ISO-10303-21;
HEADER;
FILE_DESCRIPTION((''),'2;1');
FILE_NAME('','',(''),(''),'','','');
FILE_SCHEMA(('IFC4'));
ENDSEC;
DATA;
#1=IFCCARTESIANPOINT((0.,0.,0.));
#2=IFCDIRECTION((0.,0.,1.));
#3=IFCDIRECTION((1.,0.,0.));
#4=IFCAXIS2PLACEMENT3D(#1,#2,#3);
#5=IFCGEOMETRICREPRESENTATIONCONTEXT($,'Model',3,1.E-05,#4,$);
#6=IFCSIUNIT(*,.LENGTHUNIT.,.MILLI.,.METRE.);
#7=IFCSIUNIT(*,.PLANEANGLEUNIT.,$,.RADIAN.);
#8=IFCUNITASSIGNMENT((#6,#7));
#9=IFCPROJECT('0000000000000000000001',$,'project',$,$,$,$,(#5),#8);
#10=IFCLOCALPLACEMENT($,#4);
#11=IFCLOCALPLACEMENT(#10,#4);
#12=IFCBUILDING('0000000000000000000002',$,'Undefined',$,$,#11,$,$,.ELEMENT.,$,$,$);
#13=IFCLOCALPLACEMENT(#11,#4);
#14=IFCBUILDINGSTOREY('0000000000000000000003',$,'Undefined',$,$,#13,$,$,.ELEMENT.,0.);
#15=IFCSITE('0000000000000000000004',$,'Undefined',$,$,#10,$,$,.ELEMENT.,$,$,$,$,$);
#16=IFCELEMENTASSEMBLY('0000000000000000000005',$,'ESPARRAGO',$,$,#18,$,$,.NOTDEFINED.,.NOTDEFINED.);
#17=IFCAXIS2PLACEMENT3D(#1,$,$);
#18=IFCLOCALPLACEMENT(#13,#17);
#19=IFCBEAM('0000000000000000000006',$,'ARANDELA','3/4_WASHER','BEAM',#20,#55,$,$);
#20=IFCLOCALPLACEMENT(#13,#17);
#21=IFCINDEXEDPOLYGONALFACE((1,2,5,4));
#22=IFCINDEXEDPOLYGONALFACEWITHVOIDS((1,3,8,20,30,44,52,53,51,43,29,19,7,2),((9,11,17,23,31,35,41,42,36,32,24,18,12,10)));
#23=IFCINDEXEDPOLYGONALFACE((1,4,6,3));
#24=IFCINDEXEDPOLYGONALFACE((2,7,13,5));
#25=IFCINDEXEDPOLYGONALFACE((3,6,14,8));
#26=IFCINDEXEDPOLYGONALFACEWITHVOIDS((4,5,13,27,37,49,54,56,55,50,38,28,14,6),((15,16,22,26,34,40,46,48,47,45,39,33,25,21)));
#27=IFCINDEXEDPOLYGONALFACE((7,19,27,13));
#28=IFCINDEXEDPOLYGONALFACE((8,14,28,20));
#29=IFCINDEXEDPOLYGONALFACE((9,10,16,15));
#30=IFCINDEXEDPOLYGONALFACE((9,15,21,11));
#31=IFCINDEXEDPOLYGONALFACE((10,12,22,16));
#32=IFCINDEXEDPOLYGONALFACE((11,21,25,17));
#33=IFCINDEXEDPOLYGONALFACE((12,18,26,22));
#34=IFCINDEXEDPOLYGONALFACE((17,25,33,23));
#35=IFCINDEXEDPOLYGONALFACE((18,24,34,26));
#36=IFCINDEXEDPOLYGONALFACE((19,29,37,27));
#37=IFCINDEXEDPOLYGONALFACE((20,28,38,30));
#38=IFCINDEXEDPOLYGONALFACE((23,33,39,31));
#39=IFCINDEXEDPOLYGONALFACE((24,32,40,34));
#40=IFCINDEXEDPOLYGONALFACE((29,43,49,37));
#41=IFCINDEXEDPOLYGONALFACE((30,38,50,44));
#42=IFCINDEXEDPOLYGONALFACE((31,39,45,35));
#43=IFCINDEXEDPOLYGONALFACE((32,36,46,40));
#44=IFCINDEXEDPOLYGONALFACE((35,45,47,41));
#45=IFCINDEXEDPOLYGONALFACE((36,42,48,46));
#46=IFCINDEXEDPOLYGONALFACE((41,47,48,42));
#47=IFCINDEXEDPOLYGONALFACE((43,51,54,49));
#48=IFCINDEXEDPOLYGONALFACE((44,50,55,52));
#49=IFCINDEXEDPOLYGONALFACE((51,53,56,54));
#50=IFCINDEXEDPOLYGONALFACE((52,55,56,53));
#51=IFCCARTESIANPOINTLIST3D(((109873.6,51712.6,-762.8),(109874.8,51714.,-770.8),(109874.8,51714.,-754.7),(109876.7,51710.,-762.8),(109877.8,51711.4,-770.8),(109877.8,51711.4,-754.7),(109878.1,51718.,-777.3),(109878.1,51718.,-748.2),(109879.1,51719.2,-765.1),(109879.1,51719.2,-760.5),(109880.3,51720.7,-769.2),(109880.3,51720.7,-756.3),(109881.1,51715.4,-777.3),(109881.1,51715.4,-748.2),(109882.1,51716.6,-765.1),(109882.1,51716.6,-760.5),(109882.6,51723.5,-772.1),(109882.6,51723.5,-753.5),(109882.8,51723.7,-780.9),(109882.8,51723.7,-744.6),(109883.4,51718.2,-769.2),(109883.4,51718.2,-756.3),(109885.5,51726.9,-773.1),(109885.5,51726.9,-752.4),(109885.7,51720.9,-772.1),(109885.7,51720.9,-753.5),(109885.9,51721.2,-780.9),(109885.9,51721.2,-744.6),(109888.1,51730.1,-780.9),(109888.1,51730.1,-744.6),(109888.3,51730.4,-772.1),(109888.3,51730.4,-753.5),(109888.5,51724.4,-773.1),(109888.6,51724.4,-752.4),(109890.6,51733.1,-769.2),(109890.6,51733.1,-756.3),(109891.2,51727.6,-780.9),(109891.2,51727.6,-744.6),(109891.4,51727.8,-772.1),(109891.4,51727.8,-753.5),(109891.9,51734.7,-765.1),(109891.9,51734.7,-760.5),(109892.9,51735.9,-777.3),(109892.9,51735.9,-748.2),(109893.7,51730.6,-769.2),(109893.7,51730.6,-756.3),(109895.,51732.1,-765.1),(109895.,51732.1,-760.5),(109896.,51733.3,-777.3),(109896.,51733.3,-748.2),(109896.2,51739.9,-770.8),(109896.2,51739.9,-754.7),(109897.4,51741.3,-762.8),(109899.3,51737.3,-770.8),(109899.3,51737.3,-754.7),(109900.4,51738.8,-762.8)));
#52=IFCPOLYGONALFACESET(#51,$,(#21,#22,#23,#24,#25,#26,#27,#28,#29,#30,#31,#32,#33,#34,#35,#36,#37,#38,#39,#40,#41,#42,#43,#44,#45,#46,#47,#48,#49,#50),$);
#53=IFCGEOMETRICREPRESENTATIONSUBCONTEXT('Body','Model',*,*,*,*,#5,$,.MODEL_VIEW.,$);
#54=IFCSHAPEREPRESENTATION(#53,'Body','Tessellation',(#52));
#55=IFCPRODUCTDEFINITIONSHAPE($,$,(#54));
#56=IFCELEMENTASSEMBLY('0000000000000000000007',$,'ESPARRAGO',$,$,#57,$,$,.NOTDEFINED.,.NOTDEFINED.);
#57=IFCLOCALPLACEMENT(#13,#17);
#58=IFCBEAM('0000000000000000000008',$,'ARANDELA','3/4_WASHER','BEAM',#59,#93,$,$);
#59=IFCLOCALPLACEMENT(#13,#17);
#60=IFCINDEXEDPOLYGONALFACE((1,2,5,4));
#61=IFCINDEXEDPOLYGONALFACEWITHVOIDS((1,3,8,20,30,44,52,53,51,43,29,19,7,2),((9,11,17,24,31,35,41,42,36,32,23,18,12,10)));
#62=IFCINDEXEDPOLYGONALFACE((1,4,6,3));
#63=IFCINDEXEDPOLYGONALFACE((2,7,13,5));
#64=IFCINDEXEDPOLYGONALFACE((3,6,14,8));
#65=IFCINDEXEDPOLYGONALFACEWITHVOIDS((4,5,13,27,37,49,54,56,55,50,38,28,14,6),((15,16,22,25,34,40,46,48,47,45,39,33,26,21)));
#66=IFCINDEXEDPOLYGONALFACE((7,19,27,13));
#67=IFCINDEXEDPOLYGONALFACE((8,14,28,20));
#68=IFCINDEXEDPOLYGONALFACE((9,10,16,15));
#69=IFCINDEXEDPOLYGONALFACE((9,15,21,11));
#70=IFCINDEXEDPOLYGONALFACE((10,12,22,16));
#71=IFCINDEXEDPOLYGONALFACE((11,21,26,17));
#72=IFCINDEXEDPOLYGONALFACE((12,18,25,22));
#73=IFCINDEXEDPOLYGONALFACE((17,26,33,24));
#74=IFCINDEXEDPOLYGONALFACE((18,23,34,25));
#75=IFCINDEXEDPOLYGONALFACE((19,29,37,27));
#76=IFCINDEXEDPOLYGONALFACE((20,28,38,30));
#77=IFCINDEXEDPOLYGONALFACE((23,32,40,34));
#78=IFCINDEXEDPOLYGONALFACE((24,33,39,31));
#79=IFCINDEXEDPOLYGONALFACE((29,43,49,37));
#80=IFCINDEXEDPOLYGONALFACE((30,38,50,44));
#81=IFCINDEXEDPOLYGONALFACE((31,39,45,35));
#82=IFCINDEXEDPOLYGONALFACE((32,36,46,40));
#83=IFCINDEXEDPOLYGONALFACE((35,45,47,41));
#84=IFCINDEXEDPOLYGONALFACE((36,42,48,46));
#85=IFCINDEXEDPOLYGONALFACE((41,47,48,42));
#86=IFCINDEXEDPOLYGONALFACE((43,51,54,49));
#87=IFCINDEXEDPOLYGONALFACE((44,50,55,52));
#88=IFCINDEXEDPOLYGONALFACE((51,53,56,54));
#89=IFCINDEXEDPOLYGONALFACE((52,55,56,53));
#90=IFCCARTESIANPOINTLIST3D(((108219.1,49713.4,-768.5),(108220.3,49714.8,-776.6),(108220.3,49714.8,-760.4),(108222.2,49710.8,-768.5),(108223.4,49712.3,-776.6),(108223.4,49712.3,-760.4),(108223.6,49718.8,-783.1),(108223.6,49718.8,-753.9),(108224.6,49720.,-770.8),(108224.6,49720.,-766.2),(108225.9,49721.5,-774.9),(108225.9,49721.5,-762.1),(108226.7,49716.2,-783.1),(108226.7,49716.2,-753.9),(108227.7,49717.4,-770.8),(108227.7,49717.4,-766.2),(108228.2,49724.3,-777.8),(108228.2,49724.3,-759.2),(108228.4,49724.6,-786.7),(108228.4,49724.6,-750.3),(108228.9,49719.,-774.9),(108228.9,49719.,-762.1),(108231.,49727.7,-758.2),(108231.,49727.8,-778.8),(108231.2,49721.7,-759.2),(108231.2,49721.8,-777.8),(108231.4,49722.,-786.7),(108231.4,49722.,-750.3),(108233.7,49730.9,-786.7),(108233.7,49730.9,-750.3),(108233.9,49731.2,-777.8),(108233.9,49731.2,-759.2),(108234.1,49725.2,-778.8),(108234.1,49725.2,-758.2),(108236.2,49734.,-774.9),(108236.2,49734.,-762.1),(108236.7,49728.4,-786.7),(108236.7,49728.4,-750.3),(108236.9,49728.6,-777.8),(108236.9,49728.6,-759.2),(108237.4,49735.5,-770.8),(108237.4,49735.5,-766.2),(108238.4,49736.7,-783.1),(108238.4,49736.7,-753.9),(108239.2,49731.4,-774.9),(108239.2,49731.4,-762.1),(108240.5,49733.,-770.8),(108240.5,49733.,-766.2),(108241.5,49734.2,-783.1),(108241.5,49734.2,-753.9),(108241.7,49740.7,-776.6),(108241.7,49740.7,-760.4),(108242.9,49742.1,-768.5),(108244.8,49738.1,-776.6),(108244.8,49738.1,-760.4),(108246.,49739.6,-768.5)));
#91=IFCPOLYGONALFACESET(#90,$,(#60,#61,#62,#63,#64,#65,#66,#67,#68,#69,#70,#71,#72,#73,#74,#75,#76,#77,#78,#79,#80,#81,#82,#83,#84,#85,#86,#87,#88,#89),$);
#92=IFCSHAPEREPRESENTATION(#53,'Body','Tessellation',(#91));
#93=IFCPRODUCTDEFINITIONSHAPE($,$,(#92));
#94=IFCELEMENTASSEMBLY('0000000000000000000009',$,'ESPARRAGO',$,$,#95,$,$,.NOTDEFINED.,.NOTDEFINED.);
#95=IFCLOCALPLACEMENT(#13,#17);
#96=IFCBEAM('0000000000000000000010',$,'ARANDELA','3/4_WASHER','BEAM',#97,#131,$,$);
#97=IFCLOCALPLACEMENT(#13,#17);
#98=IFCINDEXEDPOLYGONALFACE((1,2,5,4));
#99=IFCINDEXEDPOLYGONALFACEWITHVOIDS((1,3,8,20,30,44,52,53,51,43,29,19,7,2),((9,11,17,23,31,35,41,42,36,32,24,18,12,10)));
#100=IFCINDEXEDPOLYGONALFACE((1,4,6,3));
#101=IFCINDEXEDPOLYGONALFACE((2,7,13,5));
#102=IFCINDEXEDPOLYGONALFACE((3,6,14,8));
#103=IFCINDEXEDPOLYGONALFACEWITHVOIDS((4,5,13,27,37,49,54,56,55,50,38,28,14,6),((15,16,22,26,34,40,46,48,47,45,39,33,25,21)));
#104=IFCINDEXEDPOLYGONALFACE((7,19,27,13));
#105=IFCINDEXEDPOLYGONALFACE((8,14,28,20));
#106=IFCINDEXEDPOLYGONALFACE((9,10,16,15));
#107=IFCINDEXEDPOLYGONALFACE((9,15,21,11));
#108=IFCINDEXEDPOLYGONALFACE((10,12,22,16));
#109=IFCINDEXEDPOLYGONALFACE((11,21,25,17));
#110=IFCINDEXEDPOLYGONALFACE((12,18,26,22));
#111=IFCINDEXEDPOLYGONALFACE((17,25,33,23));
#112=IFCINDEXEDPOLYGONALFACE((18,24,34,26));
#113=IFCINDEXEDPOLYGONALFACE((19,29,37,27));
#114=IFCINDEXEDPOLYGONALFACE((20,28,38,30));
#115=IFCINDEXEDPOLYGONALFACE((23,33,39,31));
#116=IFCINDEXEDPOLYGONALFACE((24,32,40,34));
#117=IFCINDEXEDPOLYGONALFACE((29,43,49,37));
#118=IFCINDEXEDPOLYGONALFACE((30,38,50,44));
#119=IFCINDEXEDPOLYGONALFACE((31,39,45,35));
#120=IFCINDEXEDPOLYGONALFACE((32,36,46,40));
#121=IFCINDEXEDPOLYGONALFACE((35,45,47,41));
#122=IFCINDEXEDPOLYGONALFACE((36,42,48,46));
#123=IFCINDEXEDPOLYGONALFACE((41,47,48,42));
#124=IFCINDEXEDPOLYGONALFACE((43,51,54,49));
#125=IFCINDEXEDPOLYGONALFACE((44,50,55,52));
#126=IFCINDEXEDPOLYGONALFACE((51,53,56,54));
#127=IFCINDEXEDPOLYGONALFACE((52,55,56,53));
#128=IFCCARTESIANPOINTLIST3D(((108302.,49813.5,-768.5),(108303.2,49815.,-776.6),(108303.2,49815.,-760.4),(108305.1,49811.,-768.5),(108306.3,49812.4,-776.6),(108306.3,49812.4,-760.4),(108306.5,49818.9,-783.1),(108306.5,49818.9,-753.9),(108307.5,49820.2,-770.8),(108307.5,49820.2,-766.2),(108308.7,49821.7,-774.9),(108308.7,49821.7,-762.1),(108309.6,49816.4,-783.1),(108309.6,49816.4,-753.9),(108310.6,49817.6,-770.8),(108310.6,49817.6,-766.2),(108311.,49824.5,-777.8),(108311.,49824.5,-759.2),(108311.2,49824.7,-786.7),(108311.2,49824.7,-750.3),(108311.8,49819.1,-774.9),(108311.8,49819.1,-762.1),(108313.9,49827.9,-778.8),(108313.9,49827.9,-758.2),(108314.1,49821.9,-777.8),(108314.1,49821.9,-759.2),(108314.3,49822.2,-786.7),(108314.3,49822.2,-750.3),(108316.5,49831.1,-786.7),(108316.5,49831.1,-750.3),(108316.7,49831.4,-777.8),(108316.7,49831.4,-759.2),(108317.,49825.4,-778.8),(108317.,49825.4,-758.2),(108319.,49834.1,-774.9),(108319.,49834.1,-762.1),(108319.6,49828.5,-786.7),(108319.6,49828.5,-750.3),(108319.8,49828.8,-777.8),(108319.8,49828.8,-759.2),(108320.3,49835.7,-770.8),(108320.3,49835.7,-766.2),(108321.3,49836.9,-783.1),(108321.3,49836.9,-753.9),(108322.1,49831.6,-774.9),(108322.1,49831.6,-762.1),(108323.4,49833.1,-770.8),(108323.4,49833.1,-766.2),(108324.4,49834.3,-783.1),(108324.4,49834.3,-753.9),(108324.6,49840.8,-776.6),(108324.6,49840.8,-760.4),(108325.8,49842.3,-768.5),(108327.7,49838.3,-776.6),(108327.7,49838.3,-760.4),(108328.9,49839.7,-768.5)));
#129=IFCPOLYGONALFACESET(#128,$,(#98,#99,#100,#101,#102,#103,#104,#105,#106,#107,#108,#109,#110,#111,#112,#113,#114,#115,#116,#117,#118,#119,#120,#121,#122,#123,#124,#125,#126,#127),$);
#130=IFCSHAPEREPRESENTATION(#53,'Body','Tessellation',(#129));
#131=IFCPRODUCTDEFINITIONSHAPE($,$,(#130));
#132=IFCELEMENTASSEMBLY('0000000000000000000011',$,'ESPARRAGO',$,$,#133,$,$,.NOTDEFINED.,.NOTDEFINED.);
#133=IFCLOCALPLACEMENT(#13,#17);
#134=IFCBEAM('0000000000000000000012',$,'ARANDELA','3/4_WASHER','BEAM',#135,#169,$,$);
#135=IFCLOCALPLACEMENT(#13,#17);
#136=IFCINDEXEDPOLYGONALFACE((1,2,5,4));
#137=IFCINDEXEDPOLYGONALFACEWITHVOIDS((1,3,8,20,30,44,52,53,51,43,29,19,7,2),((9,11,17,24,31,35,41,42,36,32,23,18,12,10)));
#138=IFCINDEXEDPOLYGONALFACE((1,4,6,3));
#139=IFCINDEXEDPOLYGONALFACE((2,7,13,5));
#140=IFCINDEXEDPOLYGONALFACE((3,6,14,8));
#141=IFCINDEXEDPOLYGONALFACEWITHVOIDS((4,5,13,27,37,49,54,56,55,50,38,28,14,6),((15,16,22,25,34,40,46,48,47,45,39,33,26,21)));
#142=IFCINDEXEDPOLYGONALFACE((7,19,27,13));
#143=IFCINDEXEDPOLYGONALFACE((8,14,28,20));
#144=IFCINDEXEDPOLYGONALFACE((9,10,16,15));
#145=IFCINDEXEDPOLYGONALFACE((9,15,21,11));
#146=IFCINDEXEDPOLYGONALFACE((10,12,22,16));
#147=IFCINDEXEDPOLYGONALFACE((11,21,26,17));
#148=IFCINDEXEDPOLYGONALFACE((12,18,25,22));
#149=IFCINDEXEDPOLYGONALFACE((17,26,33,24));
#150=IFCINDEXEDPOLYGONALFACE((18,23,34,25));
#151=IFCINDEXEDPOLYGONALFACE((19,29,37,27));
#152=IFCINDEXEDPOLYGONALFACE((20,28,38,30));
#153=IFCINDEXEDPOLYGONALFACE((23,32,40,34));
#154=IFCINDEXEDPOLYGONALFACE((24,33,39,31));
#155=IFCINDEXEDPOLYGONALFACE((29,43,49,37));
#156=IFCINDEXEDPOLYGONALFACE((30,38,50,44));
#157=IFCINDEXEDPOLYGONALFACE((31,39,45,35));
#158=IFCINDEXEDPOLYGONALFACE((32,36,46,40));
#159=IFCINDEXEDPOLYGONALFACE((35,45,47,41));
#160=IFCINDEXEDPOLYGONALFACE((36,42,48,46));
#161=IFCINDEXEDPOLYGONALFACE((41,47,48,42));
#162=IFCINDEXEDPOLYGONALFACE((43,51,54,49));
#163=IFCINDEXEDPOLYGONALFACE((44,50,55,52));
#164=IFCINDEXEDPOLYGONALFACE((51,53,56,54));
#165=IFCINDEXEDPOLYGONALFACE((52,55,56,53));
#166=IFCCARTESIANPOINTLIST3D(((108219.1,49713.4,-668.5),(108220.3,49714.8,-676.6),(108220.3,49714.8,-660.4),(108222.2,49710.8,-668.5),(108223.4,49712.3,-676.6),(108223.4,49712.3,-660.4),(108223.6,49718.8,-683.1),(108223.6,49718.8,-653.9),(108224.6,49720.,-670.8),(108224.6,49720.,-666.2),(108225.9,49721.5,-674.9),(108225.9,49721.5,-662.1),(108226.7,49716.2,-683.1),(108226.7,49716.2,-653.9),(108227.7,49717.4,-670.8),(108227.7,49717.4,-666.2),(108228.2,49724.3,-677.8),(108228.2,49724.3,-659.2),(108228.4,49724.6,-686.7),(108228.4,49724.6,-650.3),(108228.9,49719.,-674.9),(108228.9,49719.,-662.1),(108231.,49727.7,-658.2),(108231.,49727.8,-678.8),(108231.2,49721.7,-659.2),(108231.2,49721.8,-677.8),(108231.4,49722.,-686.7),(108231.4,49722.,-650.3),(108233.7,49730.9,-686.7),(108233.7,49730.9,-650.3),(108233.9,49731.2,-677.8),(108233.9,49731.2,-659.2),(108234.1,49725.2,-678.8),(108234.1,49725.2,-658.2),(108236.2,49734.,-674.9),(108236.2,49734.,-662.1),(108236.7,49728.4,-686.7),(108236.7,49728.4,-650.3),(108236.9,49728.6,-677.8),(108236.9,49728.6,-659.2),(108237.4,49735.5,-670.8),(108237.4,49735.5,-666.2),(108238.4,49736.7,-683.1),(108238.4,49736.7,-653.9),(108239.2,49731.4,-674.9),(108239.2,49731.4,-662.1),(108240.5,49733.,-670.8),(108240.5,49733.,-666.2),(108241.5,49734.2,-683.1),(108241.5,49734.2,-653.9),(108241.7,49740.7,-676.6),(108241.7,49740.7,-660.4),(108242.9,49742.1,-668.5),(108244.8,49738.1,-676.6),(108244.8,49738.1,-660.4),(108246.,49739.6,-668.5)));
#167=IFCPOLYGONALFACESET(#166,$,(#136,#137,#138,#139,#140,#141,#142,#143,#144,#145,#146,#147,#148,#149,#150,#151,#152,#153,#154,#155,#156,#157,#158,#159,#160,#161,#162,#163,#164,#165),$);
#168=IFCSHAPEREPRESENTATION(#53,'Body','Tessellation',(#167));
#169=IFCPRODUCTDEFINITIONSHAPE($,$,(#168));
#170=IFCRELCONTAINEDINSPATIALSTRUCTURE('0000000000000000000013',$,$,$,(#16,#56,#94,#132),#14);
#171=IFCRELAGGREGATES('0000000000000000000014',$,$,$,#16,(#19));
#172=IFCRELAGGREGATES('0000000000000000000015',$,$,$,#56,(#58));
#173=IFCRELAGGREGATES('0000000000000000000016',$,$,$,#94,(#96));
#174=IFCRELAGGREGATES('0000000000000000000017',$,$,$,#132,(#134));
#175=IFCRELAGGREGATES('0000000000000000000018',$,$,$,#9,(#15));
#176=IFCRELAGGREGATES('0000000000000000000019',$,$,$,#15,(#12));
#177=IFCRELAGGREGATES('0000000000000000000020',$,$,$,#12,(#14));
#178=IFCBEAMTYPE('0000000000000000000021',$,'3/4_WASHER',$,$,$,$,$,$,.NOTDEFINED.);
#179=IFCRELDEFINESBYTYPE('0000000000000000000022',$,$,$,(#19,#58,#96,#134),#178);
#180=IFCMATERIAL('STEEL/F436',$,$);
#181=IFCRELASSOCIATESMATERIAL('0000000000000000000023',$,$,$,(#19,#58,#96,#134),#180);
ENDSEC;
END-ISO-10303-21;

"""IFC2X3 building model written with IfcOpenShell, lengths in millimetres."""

from ifc_helpers import new_model, si_unit, frame, origin_with_axes, place, context, subcontext, project, spatial, polyline, outline, extrude, material, type_object, element, aggregate, save


model = new_model("IFC2X3")

# Units and contexts
model_context = context("Model", 3, precision=1e-05, world=origin_with_axes())
body_context = subcontext(model_context, "Body", "Model", "MODEL_VIEW")
ifc_project = project(units=[si_unit("LENGTHUNIT", "METRE", prefix="MILLI"), si_unit("PLANEANGLEUNIT", "RADIAN")], contexts=[model_context])

# Site, building, storey
site_placement = place(None, origin_with_axes())
site = spatial("IfcSite", under=ifc_project, at=site_placement, Name="Undefined", CompositionType="ELEMENT")
building_placement = place(site_placement, origin_with_axes())
building = spatial("IfcBuilding", under=site, at=building_placement, Name="Undefined", CompositionType="ELEMENT")
storey_placement = place(building_placement, origin_with_axes())
storey = spatial("IfcBuildingStorey", under=building, at=storey_placement, Name="Undefined", CompositionType="ELEMENT", Elevation=0.0)

# Element assemblies, beams
assembly_1_placement = place(storey_placement, origin_with_axes())
assembly_1 = element("IfcElementAssembly", 1, at=assembly_1_placement, inside=storey, Name="ESPARRAGO", AssemblyPlace="NOTDEFINED", PredefinedType="NOTDEFINED")
ifc_material_1 = material(Name="STEEL/F436")
beam_type_1 = type_object("IfcBeamType", Name="3/4_WASHER", PredefinedType="NOTDEFINED")
beam_1_placement = place(assembly_1_placement, frame((109885.5, 51726.9, -762.8), z_axis=(0.000066, -0.000055, 1.0), x_axis=(0.7704, -0.637561, -0.000086)))
beam_1 = element("IfcBeam", 2, at=beam_1_placement, type_object=beam_type_1, material=ifc_material_1, Name="ARANDELA", Description="3/4_WASHER", ObjectType="BEAM", context=body_context, shape_type="SweptSolid", body=[
    extrude(outline(polyline([(-11.6, -14.6), (-16.8, -8.1), (-18.6, 0.0), (-16.8, 8.1), (-11.6, 14.6), (-4.2, 18.2), (4.2, 18.2), (11.6, 14.6), (16.8, 8.1), (18.6, 0.0), (16.8, -8.1), (11.6, -14.6), (4.2, -18.2), (-4.2, -18.2), (-11.6, -14.6)]), holes=[polyline([(-4.5, 9.3), (-8.1, 6.4), (-10.1, 2.3), (-10.1, -2.3), (-8.1, -6.4), (-4.5, -9.3), (0.0, -10.3), (4.5, -9.3), (8.1, -6.4), (10.1, -2.3), (10.1, 2.3), (8.1, 6.4), (4.5, 9.3), (0.0, 10.3), (-4.5, 9.3)])]), frame((4.0, 0.0, 0.0), z_axis=(-1.0, 0.0, 0.0), x_axis=(0.0, -1.0, 0.0)), (0.0, 0.0, 1.0), 4.0),
])
aggregate(assembly_1, [beam_1])
assembly_2_placement = place(storey_placement, origin_with_axes())
assembly_2 = element("IfcElementAssembly", 3, at=assembly_2_placement, inside=storey, Name="ESPARRAGO", AssemblyPlace="NOTDEFINED", PredefinedType="NOTDEFINED")
beam_2_placement = place(assembly_2_placement, frame((108231.0, 49727.7, -768.5), z_axis=(0.000066, -0.000055, 1.0), x_axis=(0.7704, -0.637561, -0.000086)))
beam_2 = element("IfcBeam", 4, at=beam_2_placement, type_object=beam_type_1, material=ifc_material_1, Name="ARANDELA", Description="3/4_WASHER", ObjectType="BEAM", context=body_context, shape_type="SweptSolid", body=[
    extrude(outline(polyline([(-11.6, -14.6), (-16.8, -8.1), (-18.6, 0.0), (-16.8, 8.1), (-11.6, 14.6), (-4.2, 18.2), (4.2, 18.2), (11.6, 14.6), (16.8, 8.1), (18.6, 0.0), (16.8, -8.1), (11.6, -14.6), (4.2, -18.2), (-4.2, -18.2), (-11.6, -14.6)]), holes=[polyline([(-4.5, 9.3), (-8.1, 6.4), (-10.1, 2.3), (-10.1, -2.3), (-8.1, -6.4), (-4.5, -9.3), (0.0, -10.3), (4.5, -9.3), (8.1, -6.4), (10.1, -2.3), (10.1, 2.3), (8.1, 6.4), (4.5, 9.3), (0.0, 10.3), (-4.5, 9.3)])]), frame((4.0, 0.0, 0.0), z_axis=(-1.0, 0.0, 0.0), x_axis=(0.0, -1.0, 0.0)), (0.0, 0.0, 1.0), 4.0),
])
assembly_3_placement = place(storey_placement, origin_with_axes())
assembly_3 = element("IfcElementAssembly", 5, at=assembly_3_placement, inside=storey, Name="ESPARRAGO", AssemblyPlace="NOTDEFINED", PredefinedType="NOTDEFINED")
beam_3_placement = place(assembly_3_placement, frame((108313.9, 49827.9, -768.5), z_axis=(0.000066, -0.000055, 1.0), x_axis=(0.7704, -0.637561, -0.000086)))
beam_3 = element("IfcBeam", 6, at=beam_3_placement, type_object=beam_type_1, material=ifc_material_1, Name="ARANDELA", Description="3/4_WASHER", ObjectType="BEAM", context=body_context, shape_type="SweptSolid", body=[
    extrude(outline(polyline([(-11.6, -14.6), (-16.8, -8.1), (-18.6, 0.0), (-16.8, 8.1), (-11.6, 14.6), (-4.2, 18.2), (4.2, 18.2), (11.6, 14.6), (16.8, 8.1), (18.6, 0.0), (16.8, -8.1), (11.6, -14.6), (4.2, -18.2), (-4.2, -18.2), (-11.6, -14.6)]), holes=[polyline([(-4.5, 9.3), (-8.1, 6.4), (-10.1, 2.3), (-10.1, -2.3), (-8.1, -6.4), (-4.5, -9.3), (0.0, -10.3), (4.5, -9.3), (8.1, -6.4), (10.1, -2.3), (10.1, 2.3), (8.1, 6.4), (4.5, 9.3), (0.0, 10.3), (-4.5, 9.3)])]), frame((4.0, 0.0, 0.0), z_axis=(-1.0, 0.0, 0.0), x_axis=(0.0, -1.0, 0.0)), (0.0, 0.0, 1.0), 4.0),
])
assembly_4_placement = place(storey_placement, origin_with_axes())
assembly_4 = element("IfcElementAssembly", 7, at=assembly_4_placement, inside=storey, Name="ESPARRAGO", AssemblyPlace="NOTDEFINED", PredefinedType="NOTDEFINED")
beam_4_placement = place(assembly_4_placement, frame((108231.0, 49727.8, -668.5), z_axis=(0.000066, -0.000055, 1.0), x_axis=(0.7704, -0.637561, -0.000086)))
beam_4 = element("IfcBeam", 8, at=beam_4_placement, type_object=beam_type_1, material=ifc_material_1, Name="ARANDELA", Description="3/4_WASHER", ObjectType="BEAM", context=body_context, shape_type="SweptSolid", body=[
    extrude(outline(polyline([(-11.6, -14.6), (-16.8, -8.1), (-18.6, 0.0), (-16.8, 8.1), (-11.6, 14.6), (-4.2, 18.2), (4.2, 18.2), (11.6, 14.6), (16.8, 8.1), (18.6, 0.0), (16.8, -8.1), (11.6, -14.6), (4.2, -18.2), (-4.2, -18.2), (-11.6, -14.6)]), holes=[polyline([(-4.5, 9.3), (-8.1, 6.4), (-10.1, 2.3), (-10.1, -2.3), (-8.1, -6.4), (-4.5, -9.3), (0.0, -10.3), (4.5, -9.3), (8.1, -6.4), (10.1, -2.3), (10.1, 2.3), (8.1, 6.4), (4.5, 9.3), (0.0, 10.3), (-4.5, 9.3)])]), frame((4.0, 0.0, 0.0), z_axis=(-1.0, 0.0, 0.0), x_axis=(0.0, -1.0, 0.0)), (0.0, 0.0, 1.0), 4.0),
])

aggregate(assembly_2, [beam_2])
aggregate(assembly_3, [beam_3])
aggregate(assembly_4, [beam_4])

save(model, "model.ifc")
